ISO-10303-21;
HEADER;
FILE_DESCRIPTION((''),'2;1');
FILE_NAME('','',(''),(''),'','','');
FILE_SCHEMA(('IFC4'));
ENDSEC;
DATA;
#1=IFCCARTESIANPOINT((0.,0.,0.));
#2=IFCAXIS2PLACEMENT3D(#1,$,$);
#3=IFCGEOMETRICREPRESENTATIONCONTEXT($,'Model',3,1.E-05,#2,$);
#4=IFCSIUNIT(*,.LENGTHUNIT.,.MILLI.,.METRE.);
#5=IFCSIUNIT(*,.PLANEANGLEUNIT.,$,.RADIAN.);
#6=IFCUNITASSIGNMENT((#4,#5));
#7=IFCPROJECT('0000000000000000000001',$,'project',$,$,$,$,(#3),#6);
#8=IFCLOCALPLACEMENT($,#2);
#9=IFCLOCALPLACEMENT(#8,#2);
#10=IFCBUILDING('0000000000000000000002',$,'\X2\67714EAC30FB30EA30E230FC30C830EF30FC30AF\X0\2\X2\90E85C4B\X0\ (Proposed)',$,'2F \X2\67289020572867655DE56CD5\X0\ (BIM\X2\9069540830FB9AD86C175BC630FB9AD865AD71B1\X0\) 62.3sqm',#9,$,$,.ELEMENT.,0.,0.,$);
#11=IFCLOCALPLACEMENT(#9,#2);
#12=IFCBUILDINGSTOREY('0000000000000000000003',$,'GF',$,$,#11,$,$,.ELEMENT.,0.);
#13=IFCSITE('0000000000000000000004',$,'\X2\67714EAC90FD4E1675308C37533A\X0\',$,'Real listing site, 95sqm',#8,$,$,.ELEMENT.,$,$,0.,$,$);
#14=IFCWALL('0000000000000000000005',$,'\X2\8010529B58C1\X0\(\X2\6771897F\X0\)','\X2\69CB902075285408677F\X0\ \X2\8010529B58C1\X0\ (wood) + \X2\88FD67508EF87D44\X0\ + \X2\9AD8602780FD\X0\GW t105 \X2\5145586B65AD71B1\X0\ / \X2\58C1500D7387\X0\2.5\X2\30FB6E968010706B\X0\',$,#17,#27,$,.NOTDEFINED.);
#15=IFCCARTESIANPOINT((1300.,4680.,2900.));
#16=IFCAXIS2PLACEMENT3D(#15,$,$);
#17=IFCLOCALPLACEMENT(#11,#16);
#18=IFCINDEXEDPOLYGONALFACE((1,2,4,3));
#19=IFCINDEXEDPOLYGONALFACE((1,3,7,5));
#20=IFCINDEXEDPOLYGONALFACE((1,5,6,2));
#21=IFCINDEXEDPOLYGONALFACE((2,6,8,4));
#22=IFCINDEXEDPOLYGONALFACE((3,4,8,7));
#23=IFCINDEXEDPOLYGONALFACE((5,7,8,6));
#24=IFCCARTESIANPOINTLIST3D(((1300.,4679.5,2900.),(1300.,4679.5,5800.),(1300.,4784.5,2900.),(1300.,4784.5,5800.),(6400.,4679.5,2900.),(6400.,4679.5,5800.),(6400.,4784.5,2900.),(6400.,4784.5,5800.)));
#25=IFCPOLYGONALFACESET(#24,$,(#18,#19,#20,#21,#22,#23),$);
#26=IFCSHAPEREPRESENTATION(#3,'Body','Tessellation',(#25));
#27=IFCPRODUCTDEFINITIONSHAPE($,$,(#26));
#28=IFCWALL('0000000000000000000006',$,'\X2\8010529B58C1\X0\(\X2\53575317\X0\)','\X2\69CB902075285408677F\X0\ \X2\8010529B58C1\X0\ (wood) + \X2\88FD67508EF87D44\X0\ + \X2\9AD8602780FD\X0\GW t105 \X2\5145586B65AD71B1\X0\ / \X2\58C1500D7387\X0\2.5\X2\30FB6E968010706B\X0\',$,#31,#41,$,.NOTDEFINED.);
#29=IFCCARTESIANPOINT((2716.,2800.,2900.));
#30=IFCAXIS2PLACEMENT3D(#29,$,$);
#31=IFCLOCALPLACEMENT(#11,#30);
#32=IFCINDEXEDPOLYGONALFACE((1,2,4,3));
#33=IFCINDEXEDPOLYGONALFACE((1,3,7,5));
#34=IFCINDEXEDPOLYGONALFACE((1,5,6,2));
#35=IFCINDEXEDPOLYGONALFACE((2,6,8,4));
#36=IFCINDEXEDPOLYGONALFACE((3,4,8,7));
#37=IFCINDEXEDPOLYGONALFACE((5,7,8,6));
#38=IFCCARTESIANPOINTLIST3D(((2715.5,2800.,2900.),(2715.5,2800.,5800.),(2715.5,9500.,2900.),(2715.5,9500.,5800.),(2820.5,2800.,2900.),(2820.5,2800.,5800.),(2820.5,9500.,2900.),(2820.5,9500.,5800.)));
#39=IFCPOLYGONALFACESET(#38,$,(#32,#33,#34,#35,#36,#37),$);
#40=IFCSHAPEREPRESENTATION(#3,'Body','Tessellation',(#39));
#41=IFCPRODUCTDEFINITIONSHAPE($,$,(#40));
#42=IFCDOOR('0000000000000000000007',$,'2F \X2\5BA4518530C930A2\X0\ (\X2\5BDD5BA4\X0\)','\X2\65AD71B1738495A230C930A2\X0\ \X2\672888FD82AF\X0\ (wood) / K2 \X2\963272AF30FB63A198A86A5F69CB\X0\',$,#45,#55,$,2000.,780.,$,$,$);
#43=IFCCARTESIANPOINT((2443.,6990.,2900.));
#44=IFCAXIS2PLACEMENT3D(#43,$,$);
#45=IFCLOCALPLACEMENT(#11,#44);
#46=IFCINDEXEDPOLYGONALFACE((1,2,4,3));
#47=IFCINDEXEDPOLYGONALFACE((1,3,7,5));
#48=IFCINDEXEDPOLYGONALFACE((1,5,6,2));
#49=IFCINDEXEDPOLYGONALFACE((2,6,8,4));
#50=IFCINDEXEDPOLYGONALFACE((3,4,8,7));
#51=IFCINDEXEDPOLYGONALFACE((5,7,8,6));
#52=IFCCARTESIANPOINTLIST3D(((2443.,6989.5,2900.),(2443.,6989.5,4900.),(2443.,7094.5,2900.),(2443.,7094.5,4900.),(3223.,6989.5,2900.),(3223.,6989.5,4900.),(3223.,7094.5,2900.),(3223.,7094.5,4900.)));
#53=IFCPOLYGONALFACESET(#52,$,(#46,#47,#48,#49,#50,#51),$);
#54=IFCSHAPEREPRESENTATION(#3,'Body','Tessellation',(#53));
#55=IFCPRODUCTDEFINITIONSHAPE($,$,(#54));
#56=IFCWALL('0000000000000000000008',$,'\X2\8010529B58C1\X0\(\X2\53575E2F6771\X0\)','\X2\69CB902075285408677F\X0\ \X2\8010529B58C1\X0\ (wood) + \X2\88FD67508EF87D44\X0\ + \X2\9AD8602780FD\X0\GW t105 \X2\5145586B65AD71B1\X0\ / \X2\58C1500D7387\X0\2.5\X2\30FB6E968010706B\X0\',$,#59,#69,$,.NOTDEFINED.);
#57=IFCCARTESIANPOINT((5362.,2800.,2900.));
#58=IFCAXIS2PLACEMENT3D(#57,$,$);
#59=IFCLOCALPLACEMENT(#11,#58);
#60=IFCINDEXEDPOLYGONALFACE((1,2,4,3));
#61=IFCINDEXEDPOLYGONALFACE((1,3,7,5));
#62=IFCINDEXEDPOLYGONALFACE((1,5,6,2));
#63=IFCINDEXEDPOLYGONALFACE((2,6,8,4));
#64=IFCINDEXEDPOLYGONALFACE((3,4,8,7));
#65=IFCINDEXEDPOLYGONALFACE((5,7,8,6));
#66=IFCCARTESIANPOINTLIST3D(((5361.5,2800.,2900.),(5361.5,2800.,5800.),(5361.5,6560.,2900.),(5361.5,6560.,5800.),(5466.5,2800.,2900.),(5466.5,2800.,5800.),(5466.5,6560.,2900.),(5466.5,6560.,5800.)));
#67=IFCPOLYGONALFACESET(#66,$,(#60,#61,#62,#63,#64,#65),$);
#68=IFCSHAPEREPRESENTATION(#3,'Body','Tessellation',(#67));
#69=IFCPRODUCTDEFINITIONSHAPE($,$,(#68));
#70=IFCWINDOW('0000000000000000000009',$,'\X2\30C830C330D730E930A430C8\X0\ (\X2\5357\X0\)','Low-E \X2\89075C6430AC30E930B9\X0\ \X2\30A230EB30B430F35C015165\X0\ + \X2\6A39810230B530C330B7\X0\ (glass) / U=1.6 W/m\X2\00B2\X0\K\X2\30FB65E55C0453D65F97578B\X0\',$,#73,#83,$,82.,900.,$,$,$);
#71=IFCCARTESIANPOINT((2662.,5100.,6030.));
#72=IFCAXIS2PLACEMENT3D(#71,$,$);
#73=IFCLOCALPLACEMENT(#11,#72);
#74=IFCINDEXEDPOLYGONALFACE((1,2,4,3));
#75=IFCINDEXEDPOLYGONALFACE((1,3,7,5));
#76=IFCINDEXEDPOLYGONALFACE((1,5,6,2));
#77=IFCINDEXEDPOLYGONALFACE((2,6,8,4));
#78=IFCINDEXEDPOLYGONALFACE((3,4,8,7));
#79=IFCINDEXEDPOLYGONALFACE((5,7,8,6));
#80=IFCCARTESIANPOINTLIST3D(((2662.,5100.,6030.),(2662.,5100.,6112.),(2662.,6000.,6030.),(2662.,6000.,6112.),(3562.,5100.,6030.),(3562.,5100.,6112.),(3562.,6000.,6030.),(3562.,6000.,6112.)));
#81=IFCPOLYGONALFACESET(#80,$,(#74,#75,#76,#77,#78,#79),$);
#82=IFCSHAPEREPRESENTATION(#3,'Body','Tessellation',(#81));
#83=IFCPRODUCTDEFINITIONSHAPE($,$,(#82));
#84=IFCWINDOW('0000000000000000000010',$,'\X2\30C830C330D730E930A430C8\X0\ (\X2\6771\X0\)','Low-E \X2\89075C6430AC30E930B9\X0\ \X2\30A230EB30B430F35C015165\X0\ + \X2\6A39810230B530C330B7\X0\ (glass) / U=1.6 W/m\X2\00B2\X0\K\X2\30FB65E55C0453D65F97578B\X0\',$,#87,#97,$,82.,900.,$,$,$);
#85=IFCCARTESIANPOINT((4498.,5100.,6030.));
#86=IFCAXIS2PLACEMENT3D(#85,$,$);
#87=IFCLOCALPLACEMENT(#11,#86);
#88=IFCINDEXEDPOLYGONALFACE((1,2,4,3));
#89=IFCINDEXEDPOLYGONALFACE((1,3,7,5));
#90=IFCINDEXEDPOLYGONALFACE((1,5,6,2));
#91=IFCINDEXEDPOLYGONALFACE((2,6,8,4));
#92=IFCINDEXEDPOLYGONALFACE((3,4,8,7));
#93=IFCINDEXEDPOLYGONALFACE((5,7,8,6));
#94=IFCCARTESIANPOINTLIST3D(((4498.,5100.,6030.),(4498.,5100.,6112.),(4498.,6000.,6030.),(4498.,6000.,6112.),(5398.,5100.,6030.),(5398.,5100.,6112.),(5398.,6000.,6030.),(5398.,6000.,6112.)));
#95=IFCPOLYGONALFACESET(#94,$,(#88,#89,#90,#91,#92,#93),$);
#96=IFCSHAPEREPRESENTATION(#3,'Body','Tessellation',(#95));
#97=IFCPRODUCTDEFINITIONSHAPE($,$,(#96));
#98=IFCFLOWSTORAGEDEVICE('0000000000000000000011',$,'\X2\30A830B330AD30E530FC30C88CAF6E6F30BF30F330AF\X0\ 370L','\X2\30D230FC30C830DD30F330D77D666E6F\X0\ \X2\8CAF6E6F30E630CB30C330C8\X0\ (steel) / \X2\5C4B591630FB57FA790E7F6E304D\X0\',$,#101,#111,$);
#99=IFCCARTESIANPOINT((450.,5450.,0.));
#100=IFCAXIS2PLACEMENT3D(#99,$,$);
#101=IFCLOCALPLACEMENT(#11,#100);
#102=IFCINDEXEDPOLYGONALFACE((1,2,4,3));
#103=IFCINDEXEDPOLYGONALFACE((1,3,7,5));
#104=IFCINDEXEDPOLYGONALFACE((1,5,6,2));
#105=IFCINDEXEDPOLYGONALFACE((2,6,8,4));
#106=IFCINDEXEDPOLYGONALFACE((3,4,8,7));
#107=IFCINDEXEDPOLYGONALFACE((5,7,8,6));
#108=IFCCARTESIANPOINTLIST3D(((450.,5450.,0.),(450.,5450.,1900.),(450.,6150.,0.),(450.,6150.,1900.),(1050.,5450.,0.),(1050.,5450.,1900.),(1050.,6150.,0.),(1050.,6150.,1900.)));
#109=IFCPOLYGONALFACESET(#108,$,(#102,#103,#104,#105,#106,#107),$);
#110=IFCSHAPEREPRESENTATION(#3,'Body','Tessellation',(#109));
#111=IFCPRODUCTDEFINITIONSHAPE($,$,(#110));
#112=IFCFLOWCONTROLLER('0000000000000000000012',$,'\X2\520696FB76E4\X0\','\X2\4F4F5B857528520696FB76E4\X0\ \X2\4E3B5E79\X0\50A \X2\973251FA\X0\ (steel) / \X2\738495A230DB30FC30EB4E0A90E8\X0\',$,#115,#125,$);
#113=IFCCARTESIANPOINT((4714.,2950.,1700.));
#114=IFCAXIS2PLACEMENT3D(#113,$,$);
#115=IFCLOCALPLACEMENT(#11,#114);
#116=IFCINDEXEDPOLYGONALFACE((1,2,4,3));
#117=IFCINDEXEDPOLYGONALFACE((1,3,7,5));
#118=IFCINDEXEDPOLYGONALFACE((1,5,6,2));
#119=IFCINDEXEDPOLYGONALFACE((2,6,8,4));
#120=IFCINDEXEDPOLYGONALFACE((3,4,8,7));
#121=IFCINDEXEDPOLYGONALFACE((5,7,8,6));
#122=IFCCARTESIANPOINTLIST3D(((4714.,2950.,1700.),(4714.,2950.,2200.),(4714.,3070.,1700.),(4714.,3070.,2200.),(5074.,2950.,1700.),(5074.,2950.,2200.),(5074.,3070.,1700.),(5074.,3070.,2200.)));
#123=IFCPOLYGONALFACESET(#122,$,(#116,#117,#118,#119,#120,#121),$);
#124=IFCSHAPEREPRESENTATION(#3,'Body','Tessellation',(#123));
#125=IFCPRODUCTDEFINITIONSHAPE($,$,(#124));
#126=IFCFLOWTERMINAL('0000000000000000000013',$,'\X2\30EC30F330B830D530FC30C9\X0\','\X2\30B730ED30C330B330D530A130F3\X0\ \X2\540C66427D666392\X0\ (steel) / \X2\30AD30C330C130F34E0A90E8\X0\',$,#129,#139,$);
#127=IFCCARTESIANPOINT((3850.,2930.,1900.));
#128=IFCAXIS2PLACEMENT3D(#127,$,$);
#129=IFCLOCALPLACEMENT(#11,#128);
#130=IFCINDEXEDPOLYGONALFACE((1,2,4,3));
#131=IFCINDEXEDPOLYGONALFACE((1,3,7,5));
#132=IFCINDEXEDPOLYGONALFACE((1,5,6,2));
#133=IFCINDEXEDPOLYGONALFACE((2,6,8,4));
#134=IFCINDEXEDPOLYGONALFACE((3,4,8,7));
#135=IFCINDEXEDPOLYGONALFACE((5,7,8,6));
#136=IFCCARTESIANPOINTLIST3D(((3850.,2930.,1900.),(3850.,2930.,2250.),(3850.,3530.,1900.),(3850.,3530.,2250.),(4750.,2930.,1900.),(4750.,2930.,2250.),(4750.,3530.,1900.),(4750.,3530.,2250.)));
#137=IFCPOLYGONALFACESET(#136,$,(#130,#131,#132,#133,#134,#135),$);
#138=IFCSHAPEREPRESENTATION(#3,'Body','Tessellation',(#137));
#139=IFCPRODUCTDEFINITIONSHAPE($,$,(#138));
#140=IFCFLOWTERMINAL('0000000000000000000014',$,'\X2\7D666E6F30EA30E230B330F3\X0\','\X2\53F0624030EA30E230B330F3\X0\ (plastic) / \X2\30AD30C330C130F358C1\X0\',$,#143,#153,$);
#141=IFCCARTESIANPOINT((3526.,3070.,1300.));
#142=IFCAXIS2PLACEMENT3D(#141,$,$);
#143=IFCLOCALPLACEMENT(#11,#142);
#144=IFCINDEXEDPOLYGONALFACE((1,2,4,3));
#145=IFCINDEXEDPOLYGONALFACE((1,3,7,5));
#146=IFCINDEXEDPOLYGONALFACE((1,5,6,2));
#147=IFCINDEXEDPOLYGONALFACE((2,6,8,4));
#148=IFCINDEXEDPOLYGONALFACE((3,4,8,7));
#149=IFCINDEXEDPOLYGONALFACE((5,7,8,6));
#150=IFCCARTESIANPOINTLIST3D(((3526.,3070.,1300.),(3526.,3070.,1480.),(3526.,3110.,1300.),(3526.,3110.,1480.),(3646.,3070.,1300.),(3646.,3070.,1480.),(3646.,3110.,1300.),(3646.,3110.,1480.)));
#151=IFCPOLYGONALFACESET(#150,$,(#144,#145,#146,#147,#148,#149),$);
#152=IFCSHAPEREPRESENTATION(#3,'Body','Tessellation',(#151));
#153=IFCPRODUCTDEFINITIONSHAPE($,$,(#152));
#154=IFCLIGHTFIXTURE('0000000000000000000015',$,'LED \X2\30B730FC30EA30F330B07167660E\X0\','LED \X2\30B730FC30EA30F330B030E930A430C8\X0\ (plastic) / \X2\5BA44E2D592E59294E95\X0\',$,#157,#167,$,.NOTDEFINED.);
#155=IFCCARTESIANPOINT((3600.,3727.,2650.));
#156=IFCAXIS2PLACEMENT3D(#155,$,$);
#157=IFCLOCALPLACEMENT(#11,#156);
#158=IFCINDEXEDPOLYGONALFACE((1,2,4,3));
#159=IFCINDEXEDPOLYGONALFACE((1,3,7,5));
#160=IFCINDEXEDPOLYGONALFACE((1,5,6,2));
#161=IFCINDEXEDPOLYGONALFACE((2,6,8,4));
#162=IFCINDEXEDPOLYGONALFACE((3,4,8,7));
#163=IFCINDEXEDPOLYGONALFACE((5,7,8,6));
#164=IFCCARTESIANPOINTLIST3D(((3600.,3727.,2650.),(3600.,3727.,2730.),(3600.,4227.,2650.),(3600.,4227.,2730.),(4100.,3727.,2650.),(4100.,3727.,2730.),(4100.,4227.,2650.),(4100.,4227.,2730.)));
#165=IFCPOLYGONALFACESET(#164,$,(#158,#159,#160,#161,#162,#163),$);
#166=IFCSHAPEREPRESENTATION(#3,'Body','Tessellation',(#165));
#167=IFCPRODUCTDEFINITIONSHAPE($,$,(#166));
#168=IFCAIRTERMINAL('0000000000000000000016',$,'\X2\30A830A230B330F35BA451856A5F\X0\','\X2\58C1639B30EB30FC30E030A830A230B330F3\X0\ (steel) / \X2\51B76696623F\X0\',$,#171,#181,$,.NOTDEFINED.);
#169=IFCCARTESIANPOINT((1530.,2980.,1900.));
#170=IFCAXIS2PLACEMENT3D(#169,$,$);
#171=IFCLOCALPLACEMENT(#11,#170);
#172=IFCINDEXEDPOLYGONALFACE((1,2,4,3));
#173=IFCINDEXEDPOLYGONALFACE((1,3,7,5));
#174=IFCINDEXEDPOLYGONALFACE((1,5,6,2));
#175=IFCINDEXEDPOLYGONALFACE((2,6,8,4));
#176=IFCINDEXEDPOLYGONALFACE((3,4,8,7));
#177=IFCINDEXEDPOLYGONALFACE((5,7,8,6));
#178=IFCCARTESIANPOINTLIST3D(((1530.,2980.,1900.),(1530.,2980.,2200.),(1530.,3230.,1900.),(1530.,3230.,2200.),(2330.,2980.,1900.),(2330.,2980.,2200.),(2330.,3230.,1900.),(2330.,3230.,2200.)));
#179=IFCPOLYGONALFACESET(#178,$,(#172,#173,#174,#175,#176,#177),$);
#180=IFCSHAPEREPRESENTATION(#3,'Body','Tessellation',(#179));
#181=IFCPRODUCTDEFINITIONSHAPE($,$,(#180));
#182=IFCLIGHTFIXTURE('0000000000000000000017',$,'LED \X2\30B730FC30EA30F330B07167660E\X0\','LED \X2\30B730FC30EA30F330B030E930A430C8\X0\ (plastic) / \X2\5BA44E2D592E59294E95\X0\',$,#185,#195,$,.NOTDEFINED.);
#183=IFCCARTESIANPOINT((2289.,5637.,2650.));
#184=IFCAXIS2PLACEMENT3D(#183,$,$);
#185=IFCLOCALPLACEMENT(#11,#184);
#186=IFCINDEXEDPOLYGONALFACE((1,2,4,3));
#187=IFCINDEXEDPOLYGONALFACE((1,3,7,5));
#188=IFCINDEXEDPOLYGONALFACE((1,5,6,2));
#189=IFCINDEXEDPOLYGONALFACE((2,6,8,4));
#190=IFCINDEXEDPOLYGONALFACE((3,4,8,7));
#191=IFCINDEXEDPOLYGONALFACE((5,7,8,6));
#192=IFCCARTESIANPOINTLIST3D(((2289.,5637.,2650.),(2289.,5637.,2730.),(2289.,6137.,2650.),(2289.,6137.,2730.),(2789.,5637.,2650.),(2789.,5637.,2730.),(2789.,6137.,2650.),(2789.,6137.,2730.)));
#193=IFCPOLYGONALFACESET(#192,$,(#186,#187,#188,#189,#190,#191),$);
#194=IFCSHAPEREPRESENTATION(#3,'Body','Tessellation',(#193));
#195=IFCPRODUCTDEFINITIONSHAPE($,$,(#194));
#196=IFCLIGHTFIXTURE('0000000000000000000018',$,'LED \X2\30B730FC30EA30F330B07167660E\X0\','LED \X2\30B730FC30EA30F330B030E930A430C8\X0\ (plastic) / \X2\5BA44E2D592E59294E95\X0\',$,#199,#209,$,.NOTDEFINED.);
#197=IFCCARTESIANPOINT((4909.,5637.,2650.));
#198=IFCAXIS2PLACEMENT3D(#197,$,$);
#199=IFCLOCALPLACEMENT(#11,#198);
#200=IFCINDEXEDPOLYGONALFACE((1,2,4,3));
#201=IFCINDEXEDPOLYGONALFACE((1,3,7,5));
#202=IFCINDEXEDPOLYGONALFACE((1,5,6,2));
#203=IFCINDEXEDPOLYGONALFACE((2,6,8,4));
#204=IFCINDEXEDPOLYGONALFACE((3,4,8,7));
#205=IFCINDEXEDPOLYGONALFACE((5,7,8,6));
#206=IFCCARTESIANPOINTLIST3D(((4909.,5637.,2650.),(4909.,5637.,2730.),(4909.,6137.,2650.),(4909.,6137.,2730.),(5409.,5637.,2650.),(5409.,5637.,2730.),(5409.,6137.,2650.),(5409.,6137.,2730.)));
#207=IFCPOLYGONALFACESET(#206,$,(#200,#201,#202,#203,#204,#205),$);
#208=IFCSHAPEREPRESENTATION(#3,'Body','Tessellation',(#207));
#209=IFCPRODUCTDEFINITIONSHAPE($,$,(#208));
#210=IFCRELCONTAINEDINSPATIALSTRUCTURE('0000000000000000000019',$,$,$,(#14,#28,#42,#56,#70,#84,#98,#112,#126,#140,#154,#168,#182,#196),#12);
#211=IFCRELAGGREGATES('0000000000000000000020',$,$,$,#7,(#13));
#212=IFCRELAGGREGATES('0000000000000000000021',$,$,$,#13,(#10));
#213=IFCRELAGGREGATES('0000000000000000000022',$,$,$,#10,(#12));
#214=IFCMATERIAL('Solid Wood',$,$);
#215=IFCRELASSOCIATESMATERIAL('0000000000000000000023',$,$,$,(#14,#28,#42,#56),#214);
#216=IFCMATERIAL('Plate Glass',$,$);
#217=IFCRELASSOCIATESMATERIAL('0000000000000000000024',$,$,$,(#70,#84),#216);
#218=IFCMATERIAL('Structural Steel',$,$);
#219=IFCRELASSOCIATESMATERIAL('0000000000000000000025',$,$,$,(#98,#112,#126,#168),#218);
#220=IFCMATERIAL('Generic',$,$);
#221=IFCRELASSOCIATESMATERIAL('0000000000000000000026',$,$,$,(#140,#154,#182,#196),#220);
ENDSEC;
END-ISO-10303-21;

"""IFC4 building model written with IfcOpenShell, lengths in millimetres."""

from ifc_helpers import new_model, si_unit, frame, frame_2d, origin, place, context, project, spatial, rectangle, extrude, material, element, fill, save


model = new_model("IFC4")

# Units and contexts
model_context = context("Model", 3, precision=1e-05, world=origin())
ifc_project = project(units=[si_unit("LENGTHUNIT", "METRE", prefix="MILLI"), si_unit("PLANEANGLEUNIT", "RADIAN")], contexts=[model_context])

# Site, building, storey
site_placement = place(None, origin())
site = spatial("IfcSite", under=ifc_project, at=site_placement, Name="東京都世田谷区", ObjectType="Real listing site, 95sqm", CompositionType="ELEMENT", RefElevation=0.0)
building_placement = place(site_placement, origin())
building = spatial("IfcBuilding", under=site, at=building_placement, Name="東京・リモートワーク2部屋 (Proposed)", ObjectType="2F 木造在来工法 (BIM適合・高気密・高断熱) 62.3sqm", CompositionType="ELEMENT", ElevationOfRefHeight=0.0, ElevationOfTerrain=0.0)
storey_placement = place(building_placement, origin())
storey = spatial("IfcBuildingStorey", under=building, at=storey_placement, Name="GF", CompositionType="ELEMENT", Elevation=0.0)

# Shared definitions
ifc_material_1 = material(Name="Solid Wood")

# Wall
wall_1_placement = place(storey_placement, frame((1300.0, 4680.0, 2900.0)))
element("IfcWall", 1, at=wall_1_placement, inside=storey, material=ifc_material_1, Name="耐力壁(東西)", Description="構造用合板 耐力壁 (wood) + 製材軸組 + 高性能GW t105 充填断熱 / 壁倍率2.5・準耐火", PredefinedType="NOTDEFINED", context=model_context, shape_type="SweptSolid", body=[
    extrude(rectangle(XDim=5100.0, YDim=105.0, at=frame_2d((2550.0, 52.0))), frame((1300.0, 4680.0, 2900.0)), (0.0, 0.0, 1.0), 2900.0),
])

# Wall, opening, door
wall_2_placement = place(storey_placement, frame((2716.0, 2800.0, 2900.0)))
wall_2 = element("IfcWall", 2, at=wall_2_placement, inside=storey, material=ifc_material_1, Name="耐力壁(南北)", Description="構造用合板 耐力壁 (wood) + 製材軸組 + 高性能GW t105 充填断熱 / 壁倍率2.5・準耐火", PredefinedType="NOTDEFINED", context=model_context, shape_type="SweptSolid", body=[
    extrude(rectangle(XDim=105.0, YDim=6700.0, at=frame_2d((52.0, 3350.0))), frame((2716.0, 2800.0, 2900.0)), (0.0, 0.0, 1.0), 2900.0),
])
opening_placement = place(storey_placement, frame((2443.0, 6990.0, 2900.0)))
opening = element("IfcOpeningElement", 3, at=opening_placement, cuts=wall_2, PredefinedType="NOTDEFINED", context=model_context, shape_type="SweptSolid", body=[
    extrude(rectangle(XDim=780.0, YDim=105.0, at=frame_2d((390.0, 52.0))), frame((2443.0, 6990.0, 2900.0)), (0.0, 0.0, 1.0), 2000.0),
])
door_placement = place(storey_placement, frame((2443.0, 6990.0, 2900.0)))
door = element("IfcDoor", 4, at=door_placement, inside=storey, material=ifc_material_1, Name="2F 室内ドア (寝室)", Description="断熱玄関ドア 木製芯 (wood) / K2 防犯・採風機構", OverallHeight=2000.0, OverallWidth=780.0, context=model_context, shape_type="SweptSolid", body=[
    extrude(rectangle(XDim=780.0, YDim=105.0, at=frame_2d((390.0, 52.0))), frame((2443.0, 6990.0, 2900.0)), (0.0, 0.0, 1.0), 2000.0),
])
fill(opening, door)

# Wall
wall_3_placement = place(storey_placement, frame((5362.0, 2800.0, 2900.0)))
element("IfcWall", 5, at=wall_3_placement, inside=storey, material=ifc_material_1, Name="耐力壁(南帯東)", Description="構造用合板 耐力壁 (wood) + 製材軸組 + 高性能GW t105 充填断熱 / 壁倍率2.5・準耐火", PredefinedType="NOTDEFINED", context=model_context, shape_type="SweptSolid", body=[
    extrude(rectangle(XDim=105.0, YDim=3760.0, at=frame_2d((52.0, 1880.0))), frame((5362.0, 2800.0, 2900.0)), (0.0, 0.0, 1.0), 2900.0),
])

# Windows
ifc_material_2 = material(Name="Plate Glass")
window_1_placement = place(storey_placement, frame((2662.0, 5100.0, 6030.0)))
element("IfcWindow", 6, at=window_1_placement, inside=storey, material=ifc_material_2, Name="トップライト (南)", Description="Low-E 複層ガラス アルゴン封入 + 樹脂サッシ (glass) / U=1.6 W/m²K・日射取得型", OverallHeight=82.0, OverallWidth=900.0, context=model_context, shape_type="SweptSolid", body=[
    extrude(rectangle(XDim=900.0, YDim=900.0, at=frame_2d((450.0, 450.0))), frame((2662.0, 5100.0, 6030.0)), (0.0, 0.0, 1.0), 82.0),
])
window_2_placement = place(storey_placement, frame((4498.0, 5100.0, 6030.0)))
element("IfcWindow", 7, at=window_2_placement, inside=storey, material=ifc_material_2, Name="トップライト (東)", Description="Low-E 複層ガラス アルゴン封入 + 樹脂サッシ (glass) / U=1.6 W/m²K・日射取得型", OverallHeight=82.0, OverallWidth=900.0, context=model_context, shape_type="SweptSolid", body=[
    extrude(rectangle(XDim=900.0, YDim=900.0, at=frame_2d((450.0, 450.0))), frame((4498.0, 5100.0, 6030.0)), (0.0, 0.0, 1.0), 82.0),
])

# Flow storage device
ifc_material_3 = material(Name="Structural Steel")
flow_storage_device_placement = place(storey_placement, frame((450.0, 5450.0, 0.0)))
element("IfcFlowStorageDevice", 8, at=flow_storage_device_placement, inside=storey, material=ifc_material_3, Name="エコキュート貯湯タンク 370L", Description="ヒートポンプ給湯 貯湯ユニット (steel) / 屋外・基礎置き", context=model_context, shape_type="SweptSolid", body=[
    extrude(rectangle(XDim=600.0, YDim=700.0, at=frame_2d((300.0, 350.0))), frame((450.0, 5450.0, 0.0)), (0.0, 0.0, 1.0), 1900.0),
])

# Flow controller
flow_controller_placement = place(storey_placement, frame((4714.0, 2950.0, 1700.0)))
element("IfcFlowController", 9, at=flow_controller_placement, inside=storey, material=ifc_material_3, Name="分電盤", Description="住宅用分電盤 主幹50A 露出 (steel) / 玄関ホール上部", context=model_context, shape_type="SweptSolid", body=[
    extrude(rectangle(XDim=360.0, YDim=120.0, at=frame_2d((180.0, 60.0))), frame((4714.0, 2950.0, 1700.0)), (0.0, 0.0, 1.0), 500.0),
])

# Flow terminals
flow_terminal_1_placement = place(storey_placement, frame((3850.0, 2930.0, 1900.0)))
element("IfcFlowTerminal", 10, at=flow_terminal_1_placement, inside=storey, material=ifc_material_3, Name="レンジフード", Description="シロッコファン 同時給排 (steel) / キッチン上部", context=model_context, shape_type="SweptSolid", body=[
    extrude(rectangle(XDim=900.0, YDim=600.0, at=frame_2d((450.0, 300.0))), frame((3850.0, 2930.0, 1900.0)), (0.0, 0.0, 1.0), 350.0),
])
ifc_material_4 = material(Name="Generic")
flow_terminal_2_placement = place(storey_placement, frame((3526.0, 3070.0, 1300.0)))
element("IfcFlowTerminal", 11, at=flow_terminal_2_placement, inside=storey, material=ifc_material_4, Name="給湯リモコン", Description="台所リモコン (plastic) / キッチン壁", context=model_context, shape_type="SweptSolid", body=[
    extrude(rectangle(XDim=120.0, YDim=40.0, at=frame_2d((60.0, 20.0))), frame((3526.0, 3070.0, 1300.0)), (0.0, 0.0, 1.0), 180.0),
])

# Light fixture
light_fixture_1_placement = place(storey_placement, frame((3600.0, 3727.0, 2650.0)))
element("IfcLightFixture", 12, at=light_fixture_1_placement, inside=storey, material=ifc_material_4, Name="LED シーリング照明", Description="LED シーリングライト (plastic) / 室中央天井", PredefinedType="NOTDEFINED", context=model_context, shape_type="SweptSolid", body=[
    extrude(rectangle(XDim=500.0, YDim=500.0, at=frame_2d((250.0, 250.0))), frame((3600.0, 3727.0, 2650.0)), (0.0, 0.0, 1.0), 80.0),
])

# Air terminal
air_terminal_1_placement = place(storey_placement, frame((1530.0, 2980.0, 1900.0)))
element("IfcAirTerminal", 13, at=air_terminal_1_placement, inside=storey, material=ifc_material_3, Name="エアコン室内機", Description="壁掛ルームエアコン (steel) / 冷暖房", PredefinedType="NOTDEFINED", context=model_context, shape_type="SweptSolid", body=[
    extrude(rectangle(XDim=800.0, YDim=250.0, at=frame_2d((400.0, 125.0))), frame((1530.0, 2980.0, 1900.0)), (0.0, 0.0, 1.0), 300.0),
])

# Light fixtures
light_fixture_2_placement = place(storey_placement, frame((2289.0, 5637.0, 2650.0)))
element("IfcLightFixture", 14, at=light_fixture_2_placement, inside=storey, material=ifc_material_4, Name="LED シーリング照明", Description="LED シーリングライト (plastic) / 室中央天井", PredefinedType="NOTDEFINED", context=model_context, shape_type="SweptSolid", body=[
    extrude(rectangle(XDim=500.0, YDim=500.0, at=frame_2d((250.0, 250.0))), frame((2289.0, 5637.0, 2650.0)), (0.0, 0.0, 1.0), 80.0),
])
light_fixture_3_placement = place(storey_placement, frame((4909.0, 5637.0, 2650.0)))
element("IfcLightFixture", 15, at=light_fixture_3_placement, inside=storey, material=ifc_material_4, Name="LED シーリング照明", Description="LED シーリングライト (plastic) / 室中央天井", PredefinedType="NOTDEFINED", context=model_context, shape_type="SweptSolid", body=[
    extrude(rectangle(XDim=500.0, YDim=500.0, at=frame_2d((250.0, 250.0))), frame((4909.0, 5637.0, 2650.0)), (0.0, 0.0, 1.0), 80.0),
])

save(model, "model.ifc")
